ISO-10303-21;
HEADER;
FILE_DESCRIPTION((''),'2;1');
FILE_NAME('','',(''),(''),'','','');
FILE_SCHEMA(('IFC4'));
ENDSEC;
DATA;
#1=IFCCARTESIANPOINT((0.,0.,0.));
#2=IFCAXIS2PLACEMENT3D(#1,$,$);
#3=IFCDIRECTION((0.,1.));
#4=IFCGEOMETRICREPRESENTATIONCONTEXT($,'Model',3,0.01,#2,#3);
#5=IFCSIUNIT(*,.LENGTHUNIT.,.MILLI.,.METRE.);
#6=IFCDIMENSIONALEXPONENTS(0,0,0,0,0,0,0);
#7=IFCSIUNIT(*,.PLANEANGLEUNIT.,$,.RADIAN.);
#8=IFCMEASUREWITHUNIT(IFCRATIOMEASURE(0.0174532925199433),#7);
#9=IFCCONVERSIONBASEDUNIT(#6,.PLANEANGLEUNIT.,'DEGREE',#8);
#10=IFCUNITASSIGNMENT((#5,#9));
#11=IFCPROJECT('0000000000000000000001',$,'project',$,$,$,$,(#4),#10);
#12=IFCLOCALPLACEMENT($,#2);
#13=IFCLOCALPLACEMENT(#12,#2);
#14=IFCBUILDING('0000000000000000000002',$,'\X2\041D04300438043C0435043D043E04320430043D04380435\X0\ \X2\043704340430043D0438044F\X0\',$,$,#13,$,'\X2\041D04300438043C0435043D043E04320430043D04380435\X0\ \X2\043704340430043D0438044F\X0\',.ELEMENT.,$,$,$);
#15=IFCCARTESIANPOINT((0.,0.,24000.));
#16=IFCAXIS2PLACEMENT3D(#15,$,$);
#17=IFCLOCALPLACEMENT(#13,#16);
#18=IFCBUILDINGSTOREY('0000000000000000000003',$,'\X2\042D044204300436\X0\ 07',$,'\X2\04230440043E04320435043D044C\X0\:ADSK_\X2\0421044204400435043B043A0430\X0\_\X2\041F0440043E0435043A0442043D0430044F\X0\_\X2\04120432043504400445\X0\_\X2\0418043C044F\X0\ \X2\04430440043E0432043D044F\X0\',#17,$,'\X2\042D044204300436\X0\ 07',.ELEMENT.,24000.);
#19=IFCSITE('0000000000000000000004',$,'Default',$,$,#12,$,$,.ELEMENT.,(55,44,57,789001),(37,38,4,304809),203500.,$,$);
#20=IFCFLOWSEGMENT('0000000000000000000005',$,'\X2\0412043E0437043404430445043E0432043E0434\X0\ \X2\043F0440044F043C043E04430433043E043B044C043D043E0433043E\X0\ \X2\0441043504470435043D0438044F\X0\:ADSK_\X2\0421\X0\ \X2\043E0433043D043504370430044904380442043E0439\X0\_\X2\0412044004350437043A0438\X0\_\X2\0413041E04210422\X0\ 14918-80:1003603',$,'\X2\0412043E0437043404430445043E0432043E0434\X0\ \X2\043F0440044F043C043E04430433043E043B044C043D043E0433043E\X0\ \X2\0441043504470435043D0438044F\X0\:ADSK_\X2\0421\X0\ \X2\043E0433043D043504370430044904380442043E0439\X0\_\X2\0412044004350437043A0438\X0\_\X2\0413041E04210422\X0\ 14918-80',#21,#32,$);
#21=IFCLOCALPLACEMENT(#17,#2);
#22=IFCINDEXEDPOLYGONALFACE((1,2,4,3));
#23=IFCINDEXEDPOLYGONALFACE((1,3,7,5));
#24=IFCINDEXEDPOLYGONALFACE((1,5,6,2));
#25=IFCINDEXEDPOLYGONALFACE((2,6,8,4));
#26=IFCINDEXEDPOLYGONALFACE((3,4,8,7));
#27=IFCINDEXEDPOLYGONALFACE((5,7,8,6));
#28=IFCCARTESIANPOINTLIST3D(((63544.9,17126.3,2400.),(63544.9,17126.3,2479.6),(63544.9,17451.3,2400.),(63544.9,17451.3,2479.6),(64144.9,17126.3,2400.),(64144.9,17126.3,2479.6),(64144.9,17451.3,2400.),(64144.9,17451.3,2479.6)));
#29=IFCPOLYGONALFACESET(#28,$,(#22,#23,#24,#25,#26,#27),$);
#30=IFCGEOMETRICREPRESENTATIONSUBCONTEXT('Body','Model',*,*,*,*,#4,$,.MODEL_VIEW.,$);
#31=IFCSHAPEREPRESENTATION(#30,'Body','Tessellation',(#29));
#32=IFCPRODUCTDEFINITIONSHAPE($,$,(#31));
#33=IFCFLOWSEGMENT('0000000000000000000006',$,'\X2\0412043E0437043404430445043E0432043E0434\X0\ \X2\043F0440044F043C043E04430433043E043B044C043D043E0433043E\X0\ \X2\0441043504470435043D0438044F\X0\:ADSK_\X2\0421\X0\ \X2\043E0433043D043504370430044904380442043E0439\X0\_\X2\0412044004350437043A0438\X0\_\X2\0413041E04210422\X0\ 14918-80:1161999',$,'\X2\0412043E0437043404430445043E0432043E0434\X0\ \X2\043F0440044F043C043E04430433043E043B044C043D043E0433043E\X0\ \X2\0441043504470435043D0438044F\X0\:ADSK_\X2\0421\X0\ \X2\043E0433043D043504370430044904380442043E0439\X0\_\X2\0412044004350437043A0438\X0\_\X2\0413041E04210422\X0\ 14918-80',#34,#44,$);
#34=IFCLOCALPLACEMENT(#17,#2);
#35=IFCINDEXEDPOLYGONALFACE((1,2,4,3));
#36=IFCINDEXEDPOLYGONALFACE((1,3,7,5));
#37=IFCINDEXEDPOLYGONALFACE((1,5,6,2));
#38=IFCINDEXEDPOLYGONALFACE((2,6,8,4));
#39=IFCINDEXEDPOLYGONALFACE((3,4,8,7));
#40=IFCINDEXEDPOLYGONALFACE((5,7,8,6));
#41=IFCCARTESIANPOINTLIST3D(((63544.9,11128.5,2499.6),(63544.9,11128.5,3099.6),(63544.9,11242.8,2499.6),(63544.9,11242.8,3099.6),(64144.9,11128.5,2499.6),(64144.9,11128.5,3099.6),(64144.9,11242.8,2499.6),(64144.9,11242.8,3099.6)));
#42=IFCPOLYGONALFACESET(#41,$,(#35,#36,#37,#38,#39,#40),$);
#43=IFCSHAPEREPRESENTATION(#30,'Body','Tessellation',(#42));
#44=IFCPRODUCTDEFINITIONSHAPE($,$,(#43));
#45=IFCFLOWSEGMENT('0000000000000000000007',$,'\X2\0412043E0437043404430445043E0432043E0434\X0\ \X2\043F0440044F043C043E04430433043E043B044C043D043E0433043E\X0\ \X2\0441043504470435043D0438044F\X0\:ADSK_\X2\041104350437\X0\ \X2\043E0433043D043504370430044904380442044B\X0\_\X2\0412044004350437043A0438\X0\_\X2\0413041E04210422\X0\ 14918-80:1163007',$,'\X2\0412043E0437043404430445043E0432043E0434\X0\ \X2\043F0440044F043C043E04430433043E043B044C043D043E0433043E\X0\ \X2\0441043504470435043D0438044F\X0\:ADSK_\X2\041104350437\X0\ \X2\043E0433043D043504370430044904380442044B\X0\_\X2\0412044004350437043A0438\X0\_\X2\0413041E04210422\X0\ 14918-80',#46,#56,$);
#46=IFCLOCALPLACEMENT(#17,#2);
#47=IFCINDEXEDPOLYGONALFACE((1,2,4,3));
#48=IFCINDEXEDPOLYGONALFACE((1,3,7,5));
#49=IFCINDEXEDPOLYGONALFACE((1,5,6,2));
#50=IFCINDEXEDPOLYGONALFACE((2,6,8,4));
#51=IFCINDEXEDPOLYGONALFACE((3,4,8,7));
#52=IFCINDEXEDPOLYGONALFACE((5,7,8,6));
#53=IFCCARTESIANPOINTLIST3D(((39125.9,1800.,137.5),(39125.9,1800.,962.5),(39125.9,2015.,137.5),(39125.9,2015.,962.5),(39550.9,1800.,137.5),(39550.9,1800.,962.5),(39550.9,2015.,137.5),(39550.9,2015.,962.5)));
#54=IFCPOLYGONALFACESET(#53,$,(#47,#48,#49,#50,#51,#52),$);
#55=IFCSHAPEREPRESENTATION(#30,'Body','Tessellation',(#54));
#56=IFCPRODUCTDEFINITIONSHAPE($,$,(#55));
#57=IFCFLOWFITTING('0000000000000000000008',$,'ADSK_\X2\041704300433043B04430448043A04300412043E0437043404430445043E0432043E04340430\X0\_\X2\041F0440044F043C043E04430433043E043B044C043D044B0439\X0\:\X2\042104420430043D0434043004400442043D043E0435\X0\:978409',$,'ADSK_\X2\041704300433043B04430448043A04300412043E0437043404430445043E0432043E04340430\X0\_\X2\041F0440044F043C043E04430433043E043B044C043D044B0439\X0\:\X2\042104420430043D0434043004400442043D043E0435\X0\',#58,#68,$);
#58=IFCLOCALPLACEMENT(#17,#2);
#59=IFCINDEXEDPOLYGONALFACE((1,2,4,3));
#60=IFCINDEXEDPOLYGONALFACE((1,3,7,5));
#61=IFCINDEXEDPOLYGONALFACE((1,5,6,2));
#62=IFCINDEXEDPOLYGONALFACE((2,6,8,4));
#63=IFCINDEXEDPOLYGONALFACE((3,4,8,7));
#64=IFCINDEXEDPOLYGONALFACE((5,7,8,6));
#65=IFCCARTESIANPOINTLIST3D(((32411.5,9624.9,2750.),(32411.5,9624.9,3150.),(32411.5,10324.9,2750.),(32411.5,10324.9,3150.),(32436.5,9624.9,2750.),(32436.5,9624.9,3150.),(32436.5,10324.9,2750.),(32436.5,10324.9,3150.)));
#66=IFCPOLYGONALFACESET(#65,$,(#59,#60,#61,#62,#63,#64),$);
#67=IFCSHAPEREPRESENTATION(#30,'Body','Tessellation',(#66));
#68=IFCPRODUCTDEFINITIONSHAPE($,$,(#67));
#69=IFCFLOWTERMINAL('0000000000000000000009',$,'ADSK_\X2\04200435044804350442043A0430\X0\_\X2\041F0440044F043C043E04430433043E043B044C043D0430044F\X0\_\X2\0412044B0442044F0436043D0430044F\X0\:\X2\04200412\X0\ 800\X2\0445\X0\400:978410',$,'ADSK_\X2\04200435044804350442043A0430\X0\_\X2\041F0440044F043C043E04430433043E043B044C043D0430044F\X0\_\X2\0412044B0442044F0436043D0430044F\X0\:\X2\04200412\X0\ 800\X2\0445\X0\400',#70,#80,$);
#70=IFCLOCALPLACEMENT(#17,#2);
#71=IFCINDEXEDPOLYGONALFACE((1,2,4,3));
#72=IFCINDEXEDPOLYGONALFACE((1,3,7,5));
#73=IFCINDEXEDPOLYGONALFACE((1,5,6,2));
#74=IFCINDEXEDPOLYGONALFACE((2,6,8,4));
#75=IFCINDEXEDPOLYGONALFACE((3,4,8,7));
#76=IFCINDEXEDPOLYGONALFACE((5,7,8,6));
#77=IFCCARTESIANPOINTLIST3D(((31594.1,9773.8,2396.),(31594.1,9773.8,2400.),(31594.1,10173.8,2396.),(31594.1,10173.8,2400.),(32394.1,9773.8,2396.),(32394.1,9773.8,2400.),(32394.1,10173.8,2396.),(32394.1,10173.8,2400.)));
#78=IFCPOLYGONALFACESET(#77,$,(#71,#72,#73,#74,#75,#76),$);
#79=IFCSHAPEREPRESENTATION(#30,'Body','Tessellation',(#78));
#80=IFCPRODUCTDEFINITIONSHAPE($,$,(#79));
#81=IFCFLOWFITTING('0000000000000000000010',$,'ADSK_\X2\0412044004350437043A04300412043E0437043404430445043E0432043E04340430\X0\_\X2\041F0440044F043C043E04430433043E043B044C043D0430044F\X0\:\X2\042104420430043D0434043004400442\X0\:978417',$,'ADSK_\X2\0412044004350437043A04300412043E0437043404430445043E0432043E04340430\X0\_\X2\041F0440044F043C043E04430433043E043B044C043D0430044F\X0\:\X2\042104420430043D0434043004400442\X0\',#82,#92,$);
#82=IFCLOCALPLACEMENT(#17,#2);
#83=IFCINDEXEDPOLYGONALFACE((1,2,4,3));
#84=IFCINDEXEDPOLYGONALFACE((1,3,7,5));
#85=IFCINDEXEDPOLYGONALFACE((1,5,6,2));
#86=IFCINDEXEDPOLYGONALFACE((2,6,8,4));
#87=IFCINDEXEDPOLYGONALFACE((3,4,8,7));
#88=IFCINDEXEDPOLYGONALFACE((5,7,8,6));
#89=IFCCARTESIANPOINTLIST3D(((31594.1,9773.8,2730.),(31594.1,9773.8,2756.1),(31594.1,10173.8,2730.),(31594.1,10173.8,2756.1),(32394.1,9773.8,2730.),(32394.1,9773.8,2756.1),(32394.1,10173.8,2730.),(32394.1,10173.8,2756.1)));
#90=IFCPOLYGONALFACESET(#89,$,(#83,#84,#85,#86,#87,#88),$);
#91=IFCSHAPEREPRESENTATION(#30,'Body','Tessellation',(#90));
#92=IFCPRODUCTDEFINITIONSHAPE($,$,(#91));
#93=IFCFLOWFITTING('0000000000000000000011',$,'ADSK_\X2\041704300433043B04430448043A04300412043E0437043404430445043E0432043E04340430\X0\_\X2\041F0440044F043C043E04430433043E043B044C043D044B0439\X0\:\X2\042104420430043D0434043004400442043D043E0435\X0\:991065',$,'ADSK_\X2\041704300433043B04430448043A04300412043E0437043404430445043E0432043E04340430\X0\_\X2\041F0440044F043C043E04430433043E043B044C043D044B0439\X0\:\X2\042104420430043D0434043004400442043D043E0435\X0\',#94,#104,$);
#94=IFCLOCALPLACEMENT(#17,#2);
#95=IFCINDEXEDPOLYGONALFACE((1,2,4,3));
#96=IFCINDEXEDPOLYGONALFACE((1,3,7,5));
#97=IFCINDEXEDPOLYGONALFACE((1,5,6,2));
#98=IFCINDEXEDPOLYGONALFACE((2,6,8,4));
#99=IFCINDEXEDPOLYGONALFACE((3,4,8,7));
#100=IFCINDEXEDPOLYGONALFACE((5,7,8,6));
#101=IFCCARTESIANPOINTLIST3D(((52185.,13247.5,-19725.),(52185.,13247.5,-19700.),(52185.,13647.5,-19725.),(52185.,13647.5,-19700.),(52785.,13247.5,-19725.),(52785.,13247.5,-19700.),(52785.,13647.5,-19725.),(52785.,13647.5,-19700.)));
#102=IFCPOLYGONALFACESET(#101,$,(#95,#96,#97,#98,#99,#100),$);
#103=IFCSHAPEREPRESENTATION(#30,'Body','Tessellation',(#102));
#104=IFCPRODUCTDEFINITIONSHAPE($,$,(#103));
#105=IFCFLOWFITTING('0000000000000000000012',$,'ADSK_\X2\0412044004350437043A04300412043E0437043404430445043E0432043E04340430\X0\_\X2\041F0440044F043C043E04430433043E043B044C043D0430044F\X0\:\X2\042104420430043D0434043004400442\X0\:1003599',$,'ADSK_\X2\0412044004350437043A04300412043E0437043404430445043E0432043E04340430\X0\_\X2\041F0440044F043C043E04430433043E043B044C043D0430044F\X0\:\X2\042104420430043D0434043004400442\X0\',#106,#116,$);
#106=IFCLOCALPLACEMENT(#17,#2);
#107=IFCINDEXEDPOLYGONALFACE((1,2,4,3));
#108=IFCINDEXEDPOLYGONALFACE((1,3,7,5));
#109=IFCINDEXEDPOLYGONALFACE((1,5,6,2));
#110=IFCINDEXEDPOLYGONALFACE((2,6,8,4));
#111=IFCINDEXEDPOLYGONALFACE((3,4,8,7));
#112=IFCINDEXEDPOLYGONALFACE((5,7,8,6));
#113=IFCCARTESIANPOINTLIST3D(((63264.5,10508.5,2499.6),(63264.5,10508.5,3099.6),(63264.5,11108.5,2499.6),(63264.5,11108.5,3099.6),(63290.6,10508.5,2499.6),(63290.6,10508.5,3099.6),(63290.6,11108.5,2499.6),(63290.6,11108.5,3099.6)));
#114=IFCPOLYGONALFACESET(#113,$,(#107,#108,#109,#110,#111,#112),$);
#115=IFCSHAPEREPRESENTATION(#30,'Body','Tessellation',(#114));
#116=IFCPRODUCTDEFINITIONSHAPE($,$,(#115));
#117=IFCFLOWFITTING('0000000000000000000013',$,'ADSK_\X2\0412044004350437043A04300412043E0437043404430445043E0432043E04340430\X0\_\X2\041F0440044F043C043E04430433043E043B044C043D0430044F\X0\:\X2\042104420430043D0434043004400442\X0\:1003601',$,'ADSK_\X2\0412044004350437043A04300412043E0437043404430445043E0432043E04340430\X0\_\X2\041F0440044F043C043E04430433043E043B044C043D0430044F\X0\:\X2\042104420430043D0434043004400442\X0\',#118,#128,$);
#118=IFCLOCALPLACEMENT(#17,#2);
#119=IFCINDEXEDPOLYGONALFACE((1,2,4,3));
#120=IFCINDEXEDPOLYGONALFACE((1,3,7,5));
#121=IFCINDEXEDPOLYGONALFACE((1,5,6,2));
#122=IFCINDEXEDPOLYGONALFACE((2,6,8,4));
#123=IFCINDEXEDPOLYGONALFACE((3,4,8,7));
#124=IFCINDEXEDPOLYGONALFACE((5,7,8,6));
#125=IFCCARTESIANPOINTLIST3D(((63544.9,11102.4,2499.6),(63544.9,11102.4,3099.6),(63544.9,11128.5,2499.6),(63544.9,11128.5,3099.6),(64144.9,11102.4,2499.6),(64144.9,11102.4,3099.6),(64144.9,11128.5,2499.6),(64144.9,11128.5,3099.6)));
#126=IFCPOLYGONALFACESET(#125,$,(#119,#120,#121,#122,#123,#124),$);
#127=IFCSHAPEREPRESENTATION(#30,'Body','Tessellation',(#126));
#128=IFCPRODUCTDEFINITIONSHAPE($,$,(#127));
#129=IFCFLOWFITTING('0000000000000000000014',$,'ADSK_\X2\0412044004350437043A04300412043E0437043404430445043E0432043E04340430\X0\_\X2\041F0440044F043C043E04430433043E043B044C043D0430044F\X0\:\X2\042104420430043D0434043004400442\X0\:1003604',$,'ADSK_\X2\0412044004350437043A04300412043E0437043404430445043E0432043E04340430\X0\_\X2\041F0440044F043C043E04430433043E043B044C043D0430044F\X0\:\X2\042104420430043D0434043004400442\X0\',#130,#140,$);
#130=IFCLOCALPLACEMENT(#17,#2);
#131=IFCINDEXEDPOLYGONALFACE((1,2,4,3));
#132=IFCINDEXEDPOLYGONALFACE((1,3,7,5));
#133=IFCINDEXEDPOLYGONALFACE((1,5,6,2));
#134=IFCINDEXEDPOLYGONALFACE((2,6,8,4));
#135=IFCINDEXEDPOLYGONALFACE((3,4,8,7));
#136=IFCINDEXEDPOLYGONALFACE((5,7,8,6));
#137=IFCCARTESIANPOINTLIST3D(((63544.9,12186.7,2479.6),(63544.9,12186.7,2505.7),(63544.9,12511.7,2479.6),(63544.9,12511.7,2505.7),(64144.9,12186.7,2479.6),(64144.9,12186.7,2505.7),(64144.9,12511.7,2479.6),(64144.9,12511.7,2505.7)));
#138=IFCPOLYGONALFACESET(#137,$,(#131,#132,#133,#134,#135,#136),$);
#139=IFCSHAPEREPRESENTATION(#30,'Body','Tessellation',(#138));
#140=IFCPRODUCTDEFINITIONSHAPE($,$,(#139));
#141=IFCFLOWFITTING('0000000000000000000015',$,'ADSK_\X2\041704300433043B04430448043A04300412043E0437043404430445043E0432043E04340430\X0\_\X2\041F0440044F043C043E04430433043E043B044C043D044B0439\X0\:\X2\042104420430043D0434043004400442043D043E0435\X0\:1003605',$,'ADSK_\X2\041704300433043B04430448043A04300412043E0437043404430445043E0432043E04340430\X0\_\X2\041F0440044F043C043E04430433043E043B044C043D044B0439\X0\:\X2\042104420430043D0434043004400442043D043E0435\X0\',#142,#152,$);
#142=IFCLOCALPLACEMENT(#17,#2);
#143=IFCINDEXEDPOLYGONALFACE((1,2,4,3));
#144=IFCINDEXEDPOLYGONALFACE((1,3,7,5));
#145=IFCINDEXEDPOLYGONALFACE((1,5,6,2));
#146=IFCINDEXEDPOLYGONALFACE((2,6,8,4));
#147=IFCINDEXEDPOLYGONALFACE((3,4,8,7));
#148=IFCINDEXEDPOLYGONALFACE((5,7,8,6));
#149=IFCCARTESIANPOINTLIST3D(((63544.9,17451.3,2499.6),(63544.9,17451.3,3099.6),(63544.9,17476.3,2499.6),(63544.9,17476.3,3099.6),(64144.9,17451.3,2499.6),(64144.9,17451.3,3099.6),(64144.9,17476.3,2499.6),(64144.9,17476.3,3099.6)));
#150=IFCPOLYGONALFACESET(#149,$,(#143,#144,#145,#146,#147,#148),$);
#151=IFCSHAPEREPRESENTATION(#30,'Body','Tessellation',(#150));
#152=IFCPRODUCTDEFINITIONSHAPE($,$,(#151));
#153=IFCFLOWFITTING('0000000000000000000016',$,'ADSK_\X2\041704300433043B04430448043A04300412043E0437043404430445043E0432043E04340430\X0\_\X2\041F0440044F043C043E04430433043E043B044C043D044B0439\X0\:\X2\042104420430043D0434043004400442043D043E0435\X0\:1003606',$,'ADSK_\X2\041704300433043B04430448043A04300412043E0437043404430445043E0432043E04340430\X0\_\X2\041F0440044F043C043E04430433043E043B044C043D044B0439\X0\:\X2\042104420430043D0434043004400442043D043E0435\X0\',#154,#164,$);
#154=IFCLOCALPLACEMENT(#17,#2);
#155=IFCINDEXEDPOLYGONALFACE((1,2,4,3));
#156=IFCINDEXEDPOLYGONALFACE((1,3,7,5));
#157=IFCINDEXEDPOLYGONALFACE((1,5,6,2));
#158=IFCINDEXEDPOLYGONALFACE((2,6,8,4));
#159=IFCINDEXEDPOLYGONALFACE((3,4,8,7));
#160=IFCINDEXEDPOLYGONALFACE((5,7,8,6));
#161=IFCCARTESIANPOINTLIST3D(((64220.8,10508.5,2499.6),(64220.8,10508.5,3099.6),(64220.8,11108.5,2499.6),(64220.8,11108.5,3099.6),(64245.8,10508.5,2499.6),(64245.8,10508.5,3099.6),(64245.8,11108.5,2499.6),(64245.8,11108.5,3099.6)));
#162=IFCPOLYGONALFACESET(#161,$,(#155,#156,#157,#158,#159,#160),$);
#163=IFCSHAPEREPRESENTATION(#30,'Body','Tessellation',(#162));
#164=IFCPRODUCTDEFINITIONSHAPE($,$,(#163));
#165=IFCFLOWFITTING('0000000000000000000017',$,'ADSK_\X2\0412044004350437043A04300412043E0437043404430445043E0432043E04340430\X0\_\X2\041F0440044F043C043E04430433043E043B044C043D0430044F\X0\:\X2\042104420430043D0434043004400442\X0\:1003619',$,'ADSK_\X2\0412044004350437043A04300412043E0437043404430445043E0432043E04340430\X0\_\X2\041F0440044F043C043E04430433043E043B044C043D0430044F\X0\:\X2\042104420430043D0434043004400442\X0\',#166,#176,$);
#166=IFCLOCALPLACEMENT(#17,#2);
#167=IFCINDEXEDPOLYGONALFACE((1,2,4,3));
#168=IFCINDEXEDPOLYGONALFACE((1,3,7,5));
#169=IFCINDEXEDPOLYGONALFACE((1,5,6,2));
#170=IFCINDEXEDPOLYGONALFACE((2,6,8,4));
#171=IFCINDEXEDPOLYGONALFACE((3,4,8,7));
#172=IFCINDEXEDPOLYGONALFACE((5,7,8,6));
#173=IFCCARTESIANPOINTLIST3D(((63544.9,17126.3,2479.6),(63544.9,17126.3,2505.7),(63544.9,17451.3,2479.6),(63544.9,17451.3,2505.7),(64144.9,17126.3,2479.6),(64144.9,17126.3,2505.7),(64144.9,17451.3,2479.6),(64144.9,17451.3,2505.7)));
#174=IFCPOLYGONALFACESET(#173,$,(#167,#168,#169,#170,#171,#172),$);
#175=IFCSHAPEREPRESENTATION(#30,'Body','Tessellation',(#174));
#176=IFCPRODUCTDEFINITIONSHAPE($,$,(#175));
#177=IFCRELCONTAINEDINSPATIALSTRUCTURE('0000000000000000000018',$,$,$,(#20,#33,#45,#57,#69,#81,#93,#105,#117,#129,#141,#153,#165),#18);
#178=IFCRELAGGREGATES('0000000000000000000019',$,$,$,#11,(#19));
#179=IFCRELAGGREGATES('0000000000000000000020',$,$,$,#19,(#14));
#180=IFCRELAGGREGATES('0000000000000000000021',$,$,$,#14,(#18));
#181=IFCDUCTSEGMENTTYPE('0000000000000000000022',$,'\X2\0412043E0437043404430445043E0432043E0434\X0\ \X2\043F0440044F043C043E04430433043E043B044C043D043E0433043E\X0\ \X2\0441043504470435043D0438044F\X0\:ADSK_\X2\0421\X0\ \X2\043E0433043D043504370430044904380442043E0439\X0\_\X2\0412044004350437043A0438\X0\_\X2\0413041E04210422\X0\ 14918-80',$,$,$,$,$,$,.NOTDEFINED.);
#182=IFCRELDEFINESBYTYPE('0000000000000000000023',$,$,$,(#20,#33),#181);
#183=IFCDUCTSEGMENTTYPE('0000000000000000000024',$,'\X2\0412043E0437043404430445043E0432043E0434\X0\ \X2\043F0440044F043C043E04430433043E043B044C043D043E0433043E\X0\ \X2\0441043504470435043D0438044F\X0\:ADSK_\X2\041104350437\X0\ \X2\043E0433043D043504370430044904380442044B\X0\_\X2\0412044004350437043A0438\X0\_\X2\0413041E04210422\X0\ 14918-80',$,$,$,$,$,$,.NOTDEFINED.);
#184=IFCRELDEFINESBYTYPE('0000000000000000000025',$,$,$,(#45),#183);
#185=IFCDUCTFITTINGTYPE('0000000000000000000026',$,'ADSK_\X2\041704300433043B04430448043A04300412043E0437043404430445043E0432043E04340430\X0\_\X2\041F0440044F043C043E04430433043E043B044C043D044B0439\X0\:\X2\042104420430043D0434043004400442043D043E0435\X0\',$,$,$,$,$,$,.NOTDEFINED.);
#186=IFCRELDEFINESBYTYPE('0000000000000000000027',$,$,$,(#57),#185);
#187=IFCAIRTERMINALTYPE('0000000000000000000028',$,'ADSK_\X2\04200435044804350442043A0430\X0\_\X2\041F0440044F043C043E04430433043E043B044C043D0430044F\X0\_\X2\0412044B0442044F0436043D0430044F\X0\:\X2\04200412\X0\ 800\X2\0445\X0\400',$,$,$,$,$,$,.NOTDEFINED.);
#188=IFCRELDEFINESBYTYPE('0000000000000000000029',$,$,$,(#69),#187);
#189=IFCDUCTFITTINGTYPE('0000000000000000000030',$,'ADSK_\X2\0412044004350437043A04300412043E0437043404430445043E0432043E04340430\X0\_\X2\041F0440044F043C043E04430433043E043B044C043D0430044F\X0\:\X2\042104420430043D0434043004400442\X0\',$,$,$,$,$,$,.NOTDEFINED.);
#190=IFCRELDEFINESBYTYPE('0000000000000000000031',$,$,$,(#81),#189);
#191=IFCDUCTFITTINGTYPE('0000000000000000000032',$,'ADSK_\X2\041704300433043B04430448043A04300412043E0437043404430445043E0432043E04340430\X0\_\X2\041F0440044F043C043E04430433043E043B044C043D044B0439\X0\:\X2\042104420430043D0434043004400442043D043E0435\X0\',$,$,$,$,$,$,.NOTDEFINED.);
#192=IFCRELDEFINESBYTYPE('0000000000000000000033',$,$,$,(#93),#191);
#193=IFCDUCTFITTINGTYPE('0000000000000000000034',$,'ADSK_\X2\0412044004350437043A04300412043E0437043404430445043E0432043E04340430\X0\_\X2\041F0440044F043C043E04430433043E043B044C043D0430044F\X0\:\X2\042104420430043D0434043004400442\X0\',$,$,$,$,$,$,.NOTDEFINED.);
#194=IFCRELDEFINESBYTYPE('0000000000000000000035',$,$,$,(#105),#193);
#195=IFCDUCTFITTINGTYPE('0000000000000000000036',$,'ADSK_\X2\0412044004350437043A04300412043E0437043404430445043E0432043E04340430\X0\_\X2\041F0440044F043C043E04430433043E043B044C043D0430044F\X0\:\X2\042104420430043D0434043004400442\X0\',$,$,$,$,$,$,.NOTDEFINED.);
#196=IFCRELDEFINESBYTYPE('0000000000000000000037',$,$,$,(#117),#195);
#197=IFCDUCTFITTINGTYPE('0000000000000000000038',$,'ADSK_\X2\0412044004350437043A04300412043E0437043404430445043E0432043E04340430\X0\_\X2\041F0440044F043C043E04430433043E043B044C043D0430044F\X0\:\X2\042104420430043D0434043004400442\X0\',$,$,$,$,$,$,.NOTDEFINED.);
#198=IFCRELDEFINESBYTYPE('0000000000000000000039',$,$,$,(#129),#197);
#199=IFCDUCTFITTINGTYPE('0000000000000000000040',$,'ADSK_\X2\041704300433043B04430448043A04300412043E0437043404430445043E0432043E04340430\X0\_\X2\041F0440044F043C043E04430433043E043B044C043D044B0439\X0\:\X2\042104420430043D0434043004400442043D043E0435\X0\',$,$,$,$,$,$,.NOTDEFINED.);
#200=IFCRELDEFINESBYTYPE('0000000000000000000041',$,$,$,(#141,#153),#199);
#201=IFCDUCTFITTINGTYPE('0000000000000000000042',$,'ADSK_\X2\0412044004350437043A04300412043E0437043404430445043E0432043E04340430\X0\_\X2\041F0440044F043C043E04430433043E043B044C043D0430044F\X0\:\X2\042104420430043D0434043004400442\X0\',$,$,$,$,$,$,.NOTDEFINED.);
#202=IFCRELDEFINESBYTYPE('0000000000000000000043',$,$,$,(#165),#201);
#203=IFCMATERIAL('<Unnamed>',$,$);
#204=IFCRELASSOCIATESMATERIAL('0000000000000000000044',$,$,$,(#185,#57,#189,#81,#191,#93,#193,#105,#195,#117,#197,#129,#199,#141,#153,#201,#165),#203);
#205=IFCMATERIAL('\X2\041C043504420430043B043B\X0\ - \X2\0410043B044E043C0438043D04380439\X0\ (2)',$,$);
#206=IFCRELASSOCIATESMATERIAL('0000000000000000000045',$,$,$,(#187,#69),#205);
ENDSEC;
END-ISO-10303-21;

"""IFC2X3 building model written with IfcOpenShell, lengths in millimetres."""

from ifc_helpers import new_model, entity, si_unit, converted_unit, direction, frame, origin, origin_2d_with_axis, place, context, subcontext, project, spatial, rectangle, extrude, source, transform, mapped, material, type_object, type_shapes, element, save


model = new_model("IFC2X3")

# Units and contexts
model_context = context("Model", 3, precision=0.01, world=origin(), true_north=direction((0.0, 1.0)))
body_context = subcontext(model_context, "Body", "Model", "MODEL_VIEW")
ifc_project = project(units=[si_unit("LENGTHUNIT", "METRE", prefix="MILLI"), converted_unit("PLANEANGLEUNIT", "DEGREE", entity("IfcRatioMeasure", 0.0174532925199433), si_unit("PLANEANGLEUNIT", "RADIAN"), dimensions=[0, 0, 0, 0, 0, 0, 0])], contexts=[model_context])

# Site, building, storey
site_placement = place(None, origin())
site = spatial("IfcSite", under=ifc_project, at=site_placement, Name="Default", CompositionType="ELEMENT", RefLatitude=(55, 44, 57, 789001), RefLongitude=(37, 38, 4, 304809), RefElevation=203500.0)
building_placement = place(site_placement, origin())
building = spatial("IfcBuilding", under=site, at=building_placement, Name="Наименование здания", LongName="Наименование здания", CompositionType="ELEMENT")
storey_placement = place(building_placement, frame((0.0, 0.0, 24000.0)))
storey = spatial("IfcBuildingStorey", under=building, at=storey_placement, Name="Этаж 07", ObjectType="Уровень:ADSK_Стрелка_Проектная_Вверх_Имя уровня", LongName="Этаж 07", CompositionType="ELEMENT", Elevation=24000.0)

# Flow segments
duct_segment_type_1 = type_object("IfcDuctSegmentType", Name="Воздуховод прямоугольного сечения:ADSK_С огнезащитой_Врезки_ГОСТ 14918-80", PredefinedType="NOTDEFINED")
flow_segment_1_placement = place(storey_placement, frame((63544.9, 17126.3, 2400.0)))
element("IfcFlowSegment", 1, at=flow_segment_1_placement, inside=storey, type_object=duct_segment_type_1, Name="Воздуховод прямоугольного сечения:ADSK_С огнезащитой_Врезки_ГОСТ 14918-80:1003603", ObjectType="Воздуховод прямоугольного сечения:ADSK_С огнезащитой_Врезки_ГОСТ 14918-80", context=body_context, shape_type="SweptSolid", body=[
    extrude(rectangle(XDim=600.0, YDim=325.0, at=origin_2d_with_axis()), frame((300.0, 162.5, 0.0), z_axis=(0.0, 0.0, 1.0), x_axis=(-1.0, 0.0, 0.0)), (0.0, 0.0, 1.0), 79.6),
])
flow_segment_2_placement = place(storey_placement, frame((63544.9, 11128.5, 2499.6)))
element("IfcFlowSegment", 2, at=flow_segment_2_placement, inside=storey, type_object=duct_segment_type_1, Name="Воздуховод прямоугольного сечения:ADSK_С огнезащитой_Врезки_ГОСТ 14918-80:1161999", ObjectType="Воздуховод прямоугольного сечения:ADSK_С огнезащитой_Врезки_ГОСТ 14918-80", context=body_context, shape_type="SweptSolid", body=[
    extrude(rectangle(XDim=114.3, YDim=600.0, at=origin_2d_with_axis()), frame((300.0, 57.1, 0.0), z_axis=(0.0, 0.0, 1.0), x_axis=(0.0, 1.0, 0.0)), (0.0, 0.0, 1.0), 600.0),
])
duct_segment_type_2 = type_object("IfcDuctSegmentType", Name="Воздуховод прямоугольного сечения:ADSK_Без огнезащиты_Врезки_ГОСТ 14918-80", PredefinedType="NOTDEFINED")
flow_segment_3_placement = place(storey_placement, frame((39125.9, 1800.0, 137.5)))
element("IfcFlowSegment", 3, at=flow_segment_3_placement, inside=storey, type_object=duct_segment_type_2, Name="Воздуховод прямоугольного сечения:ADSK_Без огнезащиты_Врезки_ГОСТ 14918-80:1163007", ObjectType="Воздуховод прямоугольного сечения:ADSK_Без огнезащиты_Врезки_ГОСТ 14918-80", context=body_context, shape_type="SweptSolid", body=[
    extrude(rectangle(XDim=215.0, YDim=425.0, at=origin_2d_with_axis()), frame((212.5, 107.5, 0.0), z_axis=(0.0, 0.0, 1.0), x_axis=(0.0, 1.0, 0.0)), (0.0, 0.0, 1.0), 825.0),
])

# Flow fitting
ifc_material_1 = material(Name="<Unnamed>")
duct_fitting_type_1 = type_object("IfcDuctFittingType", Name="ADSK_ЗаглушкаВоздуховода_Прямоугольный:Стандартное", PredefinedType="NOTDEFINED", material=ifc_material_1)
shared_shape_1 = source(origin(), body_context, "Body", "SweptSolid", [
    extrude(rectangle(XDim=25.0, YDim=700.0, at=origin_2d_with_axis()), frame((12.5, 0.0, -200.0)), (0.0, 0.0, 1.0), 400.0),
])
type_shapes(duct_fitting_type_1, [shared_shape_1])
flow_fitting_1_placement = place(storey_placement, frame((32411.5, 9974.9, 2950.0)))
element("IfcFlowFitting", 4, at=flow_fitting_1_placement, inside=storey, type_object=duct_fitting_type_1, material=ifc_material_1, Name="ADSK_ЗаглушкаВоздуховода_Прямоугольный:Стандартное:978409", ObjectType="ADSK_ЗаглушкаВоздуховода_Прямоугольный:Стандартное", context=body_context, shape_type="MappedRepresentation", body=[
    mapped(shared_shape_1, transform((0.0, 0.0, 0.0), scale=1.0)),
])

# Flow terminal
ifc_material_2 = material(Name="Металл - Алюминий (2)")
air_terminal_type_1 = type_object("IfcAirTerminalType", Name="ADSK_Решетка_Прямоугольная_Вытяжная:РВ 800х400", PredefinedType="NOTDEFINED", material=ifc_material_2)
shared_shape_2 = source(origin(), body_context, "Body", "SweptSolid", [
    extrude(rectangle(XDim=4.0, YDim=800.0, at=origin_2d_with_axis()), frame((0.0, -2.0, -200.0), z_axis=(0.0, 0.0, 1.0), x_axis=(0.0, 1.0, 0.0)), (0.0, 0.0, 1.0), 400.0),
])
type_shapes(air_terminal_type_1, [shared_shape_2])
flow_terminal_1_placement = place(storey_placement, frame((31994.1, 9973.8, 2400.0), z_axis=(0.0, 1.0, 0.0), x_axis=(-1.0, 0.0, 0.0)))
element("IfcFlowTerminal", 5, at=flow_terminal_1_placement, inside=storey, type_object=air_terminal_type_1, material=ifc_material_2, Name="ADSK_Решетка_Прямоугольная_Вытяжная:РВ 800х400:978410", ObjectType="ADSK_Решетка_Прямоугольная_Вытяжная:РВ 800х400", context=body_context, shape_type="MappedRepresentation", body=[
    mapped(shared_shape_2, transform((0.0, 0.0, 0.0), scale=1.0)),
])

# Flow fittings
duct_fitting_type_2 = type_object("IfcDuctFittingType", Name="ADSK_ВрезкаВоздуховода_Прямоугольная:Стандарт", PredefinedType="NOTDEFINED", material=ifc_material_1)
shared_shape_3 = source(origin(), body_context, "Body", "SweptSolid", [
    extrude(rectangle(XDim=26.1, YDim=800.0, at=origin_2d_with_axis()), frame((7.0, 0.0, -200.0)), (0.0, 0.0, 1.0), 400.0),
])
type_shapes(duct_fitting_type_2, [shared_shape_3])
flow_fitting_2_placement = place(storey_placement, frame((31994.1, 9973.8, 2750.0), z_axis=(0.0, 1.0, 0.0), x_axis=(0.0, 0.0, -1.0)))
element("IfcFlowFitting", 6, at=flow_fitting_2_placement, inside=storey, type_object=duct_fitting_type_2, material=ifc_material_1, Name="ADSK_ВрезкаВоздуховода_Прямоугольная:Стандарт:978417", ObjectType="ADSK_ВрезкаВоздуховода_Прямоугольная:Стандарт", context=body_context, shape_type="MappedRepresentation", body=[
    mapped(shared_shape_3, transform((0.0, 0.0, 0.0), scale=1.0)),
])
duct_fitting_type_3 = type_object("IfcDuctFittingType", Name="ADSK_ЗаглушкаВоздуховода_Прямоугольный:Стандартное", PredefinedType="NOTDEFINED", material=ifc_material_1)
shared_shape_4 = source(origin(), body_context, "Body", "SweptSolid", [
    extrude(rectangle(XDim=25.0, YDim=600.0, at=origin_2d_with_axis()), frame((12.5, 0.0, -200.0)), (0.0, 0.0, 1.0), 400.0),
])
type_shapes(duct_fitting_type_3, [shared_shape_4])
flow_fitting_3_placement = place(storey_placement, frame((52485.0, 13447.5, -19700.0), z_axis=(0.0, -1.0, 0.0), x_axis=(0.0, 0.0, -1.0)))
element("IfcFlowFitting", 7, at=flow_fitting_3_placement, inside=storey, type_object=duct_fitting_type_3, material=ifc_material_1, Name="ADSK_ЗаглушкаВоздуховода_Прямоугольный:Стандартное:991065", ObjectType="ADSK_ЗаглушкаВоздуховода_Прямоугольный:Стандартное", context=body_context, shape_type="MappedRepresentation", body=[
    mapped(shared_shape_4, transform((0.0, 0.0, 0.0), scale=1.0)),
])
duct_fitting_type_4 = type_object("IfcDuctFittingType", Name="ADSK_ВрезкаВоздуховода_Прямоугольная:Стандарт", PredefinedType="NOTDEFINED", material=ifc_material_1)
shared_shape_5 = source(origin(), body_context, "Body", "SweptSolid", [
    extrude(rectangle(XDim=26.1, YDim=600.0, at=origin_2d_with_axis()), frame((7.0, 0.0, -300.0)), (0.0, 0.0, 1.0), 600.0),
])
type_shapes(duct_fitting_type_4, [shared_shape_5])
flow_fitting_4_placement = place(storey_placement, frame((63270.6, 10808.5, 2799.6), z_axis=(0.0, -1.0, 0.0), x_axis=(1.0, 0.0, 0.0)))
element("IfcFlowFitting", 8, at=flow_fitting_4_placement, inside=storey, type_object=duct_fitting_type_4, material=ifc_material_1, Name="ADSK_ВрезкаВоздуховода_Прямоугольная:Стандарт:1003599", ObjectType="ADSK_ВрезкаВоздуховода_Прямоугольная:Стандарт", context=body_context, shape_type="MappedRepresentation", body=[
    mapped(shared_shape_5, transform((0.0, 0.0, 0.0), scale=1.0)),
])
duct_fitting_type_5 = type_object("IfcDuctFittingType", Name="ADSK_ВрезкаВоздуховода_Прямоугольная:Стандарт", PredefinedType="NOTDEFINED", material=ifc_material_1)
shared_shape_6 = source(origin(), body_context, "Body", "SweptSolid", [
    extrude(rectangle(XDim=600.0, YDim=26.1, at=origin_2d_with_axis()), frame((7.0, 0.0, -300.0), z_axis=(0.0, 0.0, 1.0), x_axis=(0.0, -1.0, 0.0)), (0.0, 0.0, 1.0), 600.0),
])
type_shapes(duct_fitting_type_5, [shared_shape_6])
flow_fitting_5_placement = place(storey_placement, frame((63844.9, 11108.5, 2799.6), z_axis=(0.0, 0.0, -1.0), x_axis=(0.0, 1.0, 0.0)))
element("IfcFlowFitting", 9, at=flow_fitting_5_placement, inside=storey, type_object=duct_fitting_type_5, material=ifc_material_1, Name="ADSK_ВрезкаВоздуховода_Прямоугольная:Стандарт:1003601", ObjectType="ADSK_ВрезкаВоздуховода_Прямоугольная:Стандарт", context=body_context, shape_type="MappedRepresentation", body=[
    mapped(shared_shape_6, transform((0.0, 0.0, 0.0), scale=1.0)),
])
duct_fitting_type_6 = type_object("IfcDuctFittingType", Name="ADSK_ВрезкаВоздуховода_Прямоугольная:Стандарт", PredefinedType="NOTDEFINED", material=ifc_material_1)
shared_shape_7 = source(origin(), body_context, "Body", "SweptSolid", [
    extrude(rectangle(XDim=26.1, YDim=600.0, at=origin_2d_with_axis()), frame((7.0, 0.0, -162.5)), (0.0, 0.0, 1.0), 325.0),
])
type_shapes(duct_fitting_type_6, [shared_shape_7])
flow_fitting_6_placement = place(storey_placement, frame((63844.9, 12349.2, 2499.6), z_axis=(0.0, 1.0, 0.0), x_axis=(0.0, 0.0, -1.0)))
element("IfcFlowFitting", 10, at=flow_fitting_6_placement, inside=storey, type_object=duct_fitting_type_6, material=ifc_material_1, Name="ADSK_ВрезкаВоздуховода_Прямоугольная:Стандарт:1003604", ObjectType="ADSK_ВрезкаВоздуховода_Прямоугольная:Стандарт", context=body_context, shape_type="MappedRepresentation", body=[
    mapped(shared_shape_7, transform((0.0, 0.0, 0.0), scale=1.0)),
])
duct_fitting_type_7 = type_object("IfcDuctFittingType", Name="ADSK_ЗаглушкаВоздуховода_Прямоугольный:Стандартное", PredefinedType="NOTDEFINED", material=ifc_material_1)
shared_shape_8 = source(origin(), body_context, "Body", "SweptSolid", [
    extrude(rectangle(XDim=25.0, YDim=600.0, at=origin_2d_with_axis()), frame((12.5, 0.0, -300.0)), (0.0, 0.0, 1.0), 600.0),
])
type_shapes(duct_fitting_type_7, [shared_shape_8])
flow_fitting_7_placement = place(storey_placement, frame((63844.9, 17451.3, 2799.6), z_axis=(0.0, 0.0, 1.0), x_axis=(0.0, 1.0, 0.0)))
element("IfcFlowFitting", 11, at=flow_fitting_7_placement, inside=storey, type_object=duct_fitting_type_7, material=ifc_material_1, Name="ADSK_ЗаглушкаВоздуховода_Прямоугольный:Стандартное:1003605", ObjectType="ADSK_ЗаглушкаВоздуховода_Прямоугольный:Стандартное", context=body_context, shape_type="MappedRepresentation", body=[
    mapped(shared_shape_8, transform((0.0, 0.0, 0.0), scale=1.0)),
])
flow_fitting_8_placement = place(storey_placement, frame((64220.8, 10808.5, 2799.6)))
element("IfcFlowFitting", 12, at=flow_fitting_8_placement, inside=storey, type_object=duct_fitting_type_7, material=ifc_material_1, Name="ADSK_ЗаглушкаВоздуховода_Прямоугольный:Стандартное:1003606", ObjectType="ADSK_ЗаглушкаВоздуховода_Прямоугольный:Стандартное", context=body_context, shape_type="MappedRepresentation", body=[
    mapped(shared_shape_8, transform((0.0, 0.0, 0.0), scale=1.0)),
])
duct_fitting_type_8 = type_object("IfcDuctFittingType", Name="ADSK_ВрезкаВоздуховода_Прямоугольная:Стандарт", PredefinedType="NOTDEFINED", material=ifc_material_1)
shared_shape_9 = source(origin(), body_context, "Body", "SweptSolid", [
    extrude(rectangle(XDim=600.0, YDim=26.1, at=origin_2d_with_axis()), frame((7.0, 0.0, -162.5), z_axis=(0.0, 0.0, 1.0), x_axis=(0.0, -1.0, 0.0)), (0.0, 0.0, 1.0), 325.0),
])
type_shapes(duct_fitting_type_8, [shared_shape_9])
flow_fitting_9_placement = place(storey_placement, frame((63844.9, 17288.8, 2499.6), z_axis=(0.0, -1.0, 0.0), x_axis=(0.0, 0.0, -1.0)))
element("IfcFlowFitting", 13, at=flow_fitting_9_placement, inside=storey, type_object=duct_fitting_type_8, material=ifc_material_1, Name="ADSK_ВрезкаВоздуховода_Прямоугольная:Стандарт:1003619", ObjectType="ADSK_ВрезкаВоздуховода_Прямоугольная:Стандарт", context=body_context, shape_type="MappedRepresentation", body=[
    mapped(shared_shape_9, transform((0.0, 0.0, 0.0), scale=1.0)),
])

save(model, "model.ifc")
